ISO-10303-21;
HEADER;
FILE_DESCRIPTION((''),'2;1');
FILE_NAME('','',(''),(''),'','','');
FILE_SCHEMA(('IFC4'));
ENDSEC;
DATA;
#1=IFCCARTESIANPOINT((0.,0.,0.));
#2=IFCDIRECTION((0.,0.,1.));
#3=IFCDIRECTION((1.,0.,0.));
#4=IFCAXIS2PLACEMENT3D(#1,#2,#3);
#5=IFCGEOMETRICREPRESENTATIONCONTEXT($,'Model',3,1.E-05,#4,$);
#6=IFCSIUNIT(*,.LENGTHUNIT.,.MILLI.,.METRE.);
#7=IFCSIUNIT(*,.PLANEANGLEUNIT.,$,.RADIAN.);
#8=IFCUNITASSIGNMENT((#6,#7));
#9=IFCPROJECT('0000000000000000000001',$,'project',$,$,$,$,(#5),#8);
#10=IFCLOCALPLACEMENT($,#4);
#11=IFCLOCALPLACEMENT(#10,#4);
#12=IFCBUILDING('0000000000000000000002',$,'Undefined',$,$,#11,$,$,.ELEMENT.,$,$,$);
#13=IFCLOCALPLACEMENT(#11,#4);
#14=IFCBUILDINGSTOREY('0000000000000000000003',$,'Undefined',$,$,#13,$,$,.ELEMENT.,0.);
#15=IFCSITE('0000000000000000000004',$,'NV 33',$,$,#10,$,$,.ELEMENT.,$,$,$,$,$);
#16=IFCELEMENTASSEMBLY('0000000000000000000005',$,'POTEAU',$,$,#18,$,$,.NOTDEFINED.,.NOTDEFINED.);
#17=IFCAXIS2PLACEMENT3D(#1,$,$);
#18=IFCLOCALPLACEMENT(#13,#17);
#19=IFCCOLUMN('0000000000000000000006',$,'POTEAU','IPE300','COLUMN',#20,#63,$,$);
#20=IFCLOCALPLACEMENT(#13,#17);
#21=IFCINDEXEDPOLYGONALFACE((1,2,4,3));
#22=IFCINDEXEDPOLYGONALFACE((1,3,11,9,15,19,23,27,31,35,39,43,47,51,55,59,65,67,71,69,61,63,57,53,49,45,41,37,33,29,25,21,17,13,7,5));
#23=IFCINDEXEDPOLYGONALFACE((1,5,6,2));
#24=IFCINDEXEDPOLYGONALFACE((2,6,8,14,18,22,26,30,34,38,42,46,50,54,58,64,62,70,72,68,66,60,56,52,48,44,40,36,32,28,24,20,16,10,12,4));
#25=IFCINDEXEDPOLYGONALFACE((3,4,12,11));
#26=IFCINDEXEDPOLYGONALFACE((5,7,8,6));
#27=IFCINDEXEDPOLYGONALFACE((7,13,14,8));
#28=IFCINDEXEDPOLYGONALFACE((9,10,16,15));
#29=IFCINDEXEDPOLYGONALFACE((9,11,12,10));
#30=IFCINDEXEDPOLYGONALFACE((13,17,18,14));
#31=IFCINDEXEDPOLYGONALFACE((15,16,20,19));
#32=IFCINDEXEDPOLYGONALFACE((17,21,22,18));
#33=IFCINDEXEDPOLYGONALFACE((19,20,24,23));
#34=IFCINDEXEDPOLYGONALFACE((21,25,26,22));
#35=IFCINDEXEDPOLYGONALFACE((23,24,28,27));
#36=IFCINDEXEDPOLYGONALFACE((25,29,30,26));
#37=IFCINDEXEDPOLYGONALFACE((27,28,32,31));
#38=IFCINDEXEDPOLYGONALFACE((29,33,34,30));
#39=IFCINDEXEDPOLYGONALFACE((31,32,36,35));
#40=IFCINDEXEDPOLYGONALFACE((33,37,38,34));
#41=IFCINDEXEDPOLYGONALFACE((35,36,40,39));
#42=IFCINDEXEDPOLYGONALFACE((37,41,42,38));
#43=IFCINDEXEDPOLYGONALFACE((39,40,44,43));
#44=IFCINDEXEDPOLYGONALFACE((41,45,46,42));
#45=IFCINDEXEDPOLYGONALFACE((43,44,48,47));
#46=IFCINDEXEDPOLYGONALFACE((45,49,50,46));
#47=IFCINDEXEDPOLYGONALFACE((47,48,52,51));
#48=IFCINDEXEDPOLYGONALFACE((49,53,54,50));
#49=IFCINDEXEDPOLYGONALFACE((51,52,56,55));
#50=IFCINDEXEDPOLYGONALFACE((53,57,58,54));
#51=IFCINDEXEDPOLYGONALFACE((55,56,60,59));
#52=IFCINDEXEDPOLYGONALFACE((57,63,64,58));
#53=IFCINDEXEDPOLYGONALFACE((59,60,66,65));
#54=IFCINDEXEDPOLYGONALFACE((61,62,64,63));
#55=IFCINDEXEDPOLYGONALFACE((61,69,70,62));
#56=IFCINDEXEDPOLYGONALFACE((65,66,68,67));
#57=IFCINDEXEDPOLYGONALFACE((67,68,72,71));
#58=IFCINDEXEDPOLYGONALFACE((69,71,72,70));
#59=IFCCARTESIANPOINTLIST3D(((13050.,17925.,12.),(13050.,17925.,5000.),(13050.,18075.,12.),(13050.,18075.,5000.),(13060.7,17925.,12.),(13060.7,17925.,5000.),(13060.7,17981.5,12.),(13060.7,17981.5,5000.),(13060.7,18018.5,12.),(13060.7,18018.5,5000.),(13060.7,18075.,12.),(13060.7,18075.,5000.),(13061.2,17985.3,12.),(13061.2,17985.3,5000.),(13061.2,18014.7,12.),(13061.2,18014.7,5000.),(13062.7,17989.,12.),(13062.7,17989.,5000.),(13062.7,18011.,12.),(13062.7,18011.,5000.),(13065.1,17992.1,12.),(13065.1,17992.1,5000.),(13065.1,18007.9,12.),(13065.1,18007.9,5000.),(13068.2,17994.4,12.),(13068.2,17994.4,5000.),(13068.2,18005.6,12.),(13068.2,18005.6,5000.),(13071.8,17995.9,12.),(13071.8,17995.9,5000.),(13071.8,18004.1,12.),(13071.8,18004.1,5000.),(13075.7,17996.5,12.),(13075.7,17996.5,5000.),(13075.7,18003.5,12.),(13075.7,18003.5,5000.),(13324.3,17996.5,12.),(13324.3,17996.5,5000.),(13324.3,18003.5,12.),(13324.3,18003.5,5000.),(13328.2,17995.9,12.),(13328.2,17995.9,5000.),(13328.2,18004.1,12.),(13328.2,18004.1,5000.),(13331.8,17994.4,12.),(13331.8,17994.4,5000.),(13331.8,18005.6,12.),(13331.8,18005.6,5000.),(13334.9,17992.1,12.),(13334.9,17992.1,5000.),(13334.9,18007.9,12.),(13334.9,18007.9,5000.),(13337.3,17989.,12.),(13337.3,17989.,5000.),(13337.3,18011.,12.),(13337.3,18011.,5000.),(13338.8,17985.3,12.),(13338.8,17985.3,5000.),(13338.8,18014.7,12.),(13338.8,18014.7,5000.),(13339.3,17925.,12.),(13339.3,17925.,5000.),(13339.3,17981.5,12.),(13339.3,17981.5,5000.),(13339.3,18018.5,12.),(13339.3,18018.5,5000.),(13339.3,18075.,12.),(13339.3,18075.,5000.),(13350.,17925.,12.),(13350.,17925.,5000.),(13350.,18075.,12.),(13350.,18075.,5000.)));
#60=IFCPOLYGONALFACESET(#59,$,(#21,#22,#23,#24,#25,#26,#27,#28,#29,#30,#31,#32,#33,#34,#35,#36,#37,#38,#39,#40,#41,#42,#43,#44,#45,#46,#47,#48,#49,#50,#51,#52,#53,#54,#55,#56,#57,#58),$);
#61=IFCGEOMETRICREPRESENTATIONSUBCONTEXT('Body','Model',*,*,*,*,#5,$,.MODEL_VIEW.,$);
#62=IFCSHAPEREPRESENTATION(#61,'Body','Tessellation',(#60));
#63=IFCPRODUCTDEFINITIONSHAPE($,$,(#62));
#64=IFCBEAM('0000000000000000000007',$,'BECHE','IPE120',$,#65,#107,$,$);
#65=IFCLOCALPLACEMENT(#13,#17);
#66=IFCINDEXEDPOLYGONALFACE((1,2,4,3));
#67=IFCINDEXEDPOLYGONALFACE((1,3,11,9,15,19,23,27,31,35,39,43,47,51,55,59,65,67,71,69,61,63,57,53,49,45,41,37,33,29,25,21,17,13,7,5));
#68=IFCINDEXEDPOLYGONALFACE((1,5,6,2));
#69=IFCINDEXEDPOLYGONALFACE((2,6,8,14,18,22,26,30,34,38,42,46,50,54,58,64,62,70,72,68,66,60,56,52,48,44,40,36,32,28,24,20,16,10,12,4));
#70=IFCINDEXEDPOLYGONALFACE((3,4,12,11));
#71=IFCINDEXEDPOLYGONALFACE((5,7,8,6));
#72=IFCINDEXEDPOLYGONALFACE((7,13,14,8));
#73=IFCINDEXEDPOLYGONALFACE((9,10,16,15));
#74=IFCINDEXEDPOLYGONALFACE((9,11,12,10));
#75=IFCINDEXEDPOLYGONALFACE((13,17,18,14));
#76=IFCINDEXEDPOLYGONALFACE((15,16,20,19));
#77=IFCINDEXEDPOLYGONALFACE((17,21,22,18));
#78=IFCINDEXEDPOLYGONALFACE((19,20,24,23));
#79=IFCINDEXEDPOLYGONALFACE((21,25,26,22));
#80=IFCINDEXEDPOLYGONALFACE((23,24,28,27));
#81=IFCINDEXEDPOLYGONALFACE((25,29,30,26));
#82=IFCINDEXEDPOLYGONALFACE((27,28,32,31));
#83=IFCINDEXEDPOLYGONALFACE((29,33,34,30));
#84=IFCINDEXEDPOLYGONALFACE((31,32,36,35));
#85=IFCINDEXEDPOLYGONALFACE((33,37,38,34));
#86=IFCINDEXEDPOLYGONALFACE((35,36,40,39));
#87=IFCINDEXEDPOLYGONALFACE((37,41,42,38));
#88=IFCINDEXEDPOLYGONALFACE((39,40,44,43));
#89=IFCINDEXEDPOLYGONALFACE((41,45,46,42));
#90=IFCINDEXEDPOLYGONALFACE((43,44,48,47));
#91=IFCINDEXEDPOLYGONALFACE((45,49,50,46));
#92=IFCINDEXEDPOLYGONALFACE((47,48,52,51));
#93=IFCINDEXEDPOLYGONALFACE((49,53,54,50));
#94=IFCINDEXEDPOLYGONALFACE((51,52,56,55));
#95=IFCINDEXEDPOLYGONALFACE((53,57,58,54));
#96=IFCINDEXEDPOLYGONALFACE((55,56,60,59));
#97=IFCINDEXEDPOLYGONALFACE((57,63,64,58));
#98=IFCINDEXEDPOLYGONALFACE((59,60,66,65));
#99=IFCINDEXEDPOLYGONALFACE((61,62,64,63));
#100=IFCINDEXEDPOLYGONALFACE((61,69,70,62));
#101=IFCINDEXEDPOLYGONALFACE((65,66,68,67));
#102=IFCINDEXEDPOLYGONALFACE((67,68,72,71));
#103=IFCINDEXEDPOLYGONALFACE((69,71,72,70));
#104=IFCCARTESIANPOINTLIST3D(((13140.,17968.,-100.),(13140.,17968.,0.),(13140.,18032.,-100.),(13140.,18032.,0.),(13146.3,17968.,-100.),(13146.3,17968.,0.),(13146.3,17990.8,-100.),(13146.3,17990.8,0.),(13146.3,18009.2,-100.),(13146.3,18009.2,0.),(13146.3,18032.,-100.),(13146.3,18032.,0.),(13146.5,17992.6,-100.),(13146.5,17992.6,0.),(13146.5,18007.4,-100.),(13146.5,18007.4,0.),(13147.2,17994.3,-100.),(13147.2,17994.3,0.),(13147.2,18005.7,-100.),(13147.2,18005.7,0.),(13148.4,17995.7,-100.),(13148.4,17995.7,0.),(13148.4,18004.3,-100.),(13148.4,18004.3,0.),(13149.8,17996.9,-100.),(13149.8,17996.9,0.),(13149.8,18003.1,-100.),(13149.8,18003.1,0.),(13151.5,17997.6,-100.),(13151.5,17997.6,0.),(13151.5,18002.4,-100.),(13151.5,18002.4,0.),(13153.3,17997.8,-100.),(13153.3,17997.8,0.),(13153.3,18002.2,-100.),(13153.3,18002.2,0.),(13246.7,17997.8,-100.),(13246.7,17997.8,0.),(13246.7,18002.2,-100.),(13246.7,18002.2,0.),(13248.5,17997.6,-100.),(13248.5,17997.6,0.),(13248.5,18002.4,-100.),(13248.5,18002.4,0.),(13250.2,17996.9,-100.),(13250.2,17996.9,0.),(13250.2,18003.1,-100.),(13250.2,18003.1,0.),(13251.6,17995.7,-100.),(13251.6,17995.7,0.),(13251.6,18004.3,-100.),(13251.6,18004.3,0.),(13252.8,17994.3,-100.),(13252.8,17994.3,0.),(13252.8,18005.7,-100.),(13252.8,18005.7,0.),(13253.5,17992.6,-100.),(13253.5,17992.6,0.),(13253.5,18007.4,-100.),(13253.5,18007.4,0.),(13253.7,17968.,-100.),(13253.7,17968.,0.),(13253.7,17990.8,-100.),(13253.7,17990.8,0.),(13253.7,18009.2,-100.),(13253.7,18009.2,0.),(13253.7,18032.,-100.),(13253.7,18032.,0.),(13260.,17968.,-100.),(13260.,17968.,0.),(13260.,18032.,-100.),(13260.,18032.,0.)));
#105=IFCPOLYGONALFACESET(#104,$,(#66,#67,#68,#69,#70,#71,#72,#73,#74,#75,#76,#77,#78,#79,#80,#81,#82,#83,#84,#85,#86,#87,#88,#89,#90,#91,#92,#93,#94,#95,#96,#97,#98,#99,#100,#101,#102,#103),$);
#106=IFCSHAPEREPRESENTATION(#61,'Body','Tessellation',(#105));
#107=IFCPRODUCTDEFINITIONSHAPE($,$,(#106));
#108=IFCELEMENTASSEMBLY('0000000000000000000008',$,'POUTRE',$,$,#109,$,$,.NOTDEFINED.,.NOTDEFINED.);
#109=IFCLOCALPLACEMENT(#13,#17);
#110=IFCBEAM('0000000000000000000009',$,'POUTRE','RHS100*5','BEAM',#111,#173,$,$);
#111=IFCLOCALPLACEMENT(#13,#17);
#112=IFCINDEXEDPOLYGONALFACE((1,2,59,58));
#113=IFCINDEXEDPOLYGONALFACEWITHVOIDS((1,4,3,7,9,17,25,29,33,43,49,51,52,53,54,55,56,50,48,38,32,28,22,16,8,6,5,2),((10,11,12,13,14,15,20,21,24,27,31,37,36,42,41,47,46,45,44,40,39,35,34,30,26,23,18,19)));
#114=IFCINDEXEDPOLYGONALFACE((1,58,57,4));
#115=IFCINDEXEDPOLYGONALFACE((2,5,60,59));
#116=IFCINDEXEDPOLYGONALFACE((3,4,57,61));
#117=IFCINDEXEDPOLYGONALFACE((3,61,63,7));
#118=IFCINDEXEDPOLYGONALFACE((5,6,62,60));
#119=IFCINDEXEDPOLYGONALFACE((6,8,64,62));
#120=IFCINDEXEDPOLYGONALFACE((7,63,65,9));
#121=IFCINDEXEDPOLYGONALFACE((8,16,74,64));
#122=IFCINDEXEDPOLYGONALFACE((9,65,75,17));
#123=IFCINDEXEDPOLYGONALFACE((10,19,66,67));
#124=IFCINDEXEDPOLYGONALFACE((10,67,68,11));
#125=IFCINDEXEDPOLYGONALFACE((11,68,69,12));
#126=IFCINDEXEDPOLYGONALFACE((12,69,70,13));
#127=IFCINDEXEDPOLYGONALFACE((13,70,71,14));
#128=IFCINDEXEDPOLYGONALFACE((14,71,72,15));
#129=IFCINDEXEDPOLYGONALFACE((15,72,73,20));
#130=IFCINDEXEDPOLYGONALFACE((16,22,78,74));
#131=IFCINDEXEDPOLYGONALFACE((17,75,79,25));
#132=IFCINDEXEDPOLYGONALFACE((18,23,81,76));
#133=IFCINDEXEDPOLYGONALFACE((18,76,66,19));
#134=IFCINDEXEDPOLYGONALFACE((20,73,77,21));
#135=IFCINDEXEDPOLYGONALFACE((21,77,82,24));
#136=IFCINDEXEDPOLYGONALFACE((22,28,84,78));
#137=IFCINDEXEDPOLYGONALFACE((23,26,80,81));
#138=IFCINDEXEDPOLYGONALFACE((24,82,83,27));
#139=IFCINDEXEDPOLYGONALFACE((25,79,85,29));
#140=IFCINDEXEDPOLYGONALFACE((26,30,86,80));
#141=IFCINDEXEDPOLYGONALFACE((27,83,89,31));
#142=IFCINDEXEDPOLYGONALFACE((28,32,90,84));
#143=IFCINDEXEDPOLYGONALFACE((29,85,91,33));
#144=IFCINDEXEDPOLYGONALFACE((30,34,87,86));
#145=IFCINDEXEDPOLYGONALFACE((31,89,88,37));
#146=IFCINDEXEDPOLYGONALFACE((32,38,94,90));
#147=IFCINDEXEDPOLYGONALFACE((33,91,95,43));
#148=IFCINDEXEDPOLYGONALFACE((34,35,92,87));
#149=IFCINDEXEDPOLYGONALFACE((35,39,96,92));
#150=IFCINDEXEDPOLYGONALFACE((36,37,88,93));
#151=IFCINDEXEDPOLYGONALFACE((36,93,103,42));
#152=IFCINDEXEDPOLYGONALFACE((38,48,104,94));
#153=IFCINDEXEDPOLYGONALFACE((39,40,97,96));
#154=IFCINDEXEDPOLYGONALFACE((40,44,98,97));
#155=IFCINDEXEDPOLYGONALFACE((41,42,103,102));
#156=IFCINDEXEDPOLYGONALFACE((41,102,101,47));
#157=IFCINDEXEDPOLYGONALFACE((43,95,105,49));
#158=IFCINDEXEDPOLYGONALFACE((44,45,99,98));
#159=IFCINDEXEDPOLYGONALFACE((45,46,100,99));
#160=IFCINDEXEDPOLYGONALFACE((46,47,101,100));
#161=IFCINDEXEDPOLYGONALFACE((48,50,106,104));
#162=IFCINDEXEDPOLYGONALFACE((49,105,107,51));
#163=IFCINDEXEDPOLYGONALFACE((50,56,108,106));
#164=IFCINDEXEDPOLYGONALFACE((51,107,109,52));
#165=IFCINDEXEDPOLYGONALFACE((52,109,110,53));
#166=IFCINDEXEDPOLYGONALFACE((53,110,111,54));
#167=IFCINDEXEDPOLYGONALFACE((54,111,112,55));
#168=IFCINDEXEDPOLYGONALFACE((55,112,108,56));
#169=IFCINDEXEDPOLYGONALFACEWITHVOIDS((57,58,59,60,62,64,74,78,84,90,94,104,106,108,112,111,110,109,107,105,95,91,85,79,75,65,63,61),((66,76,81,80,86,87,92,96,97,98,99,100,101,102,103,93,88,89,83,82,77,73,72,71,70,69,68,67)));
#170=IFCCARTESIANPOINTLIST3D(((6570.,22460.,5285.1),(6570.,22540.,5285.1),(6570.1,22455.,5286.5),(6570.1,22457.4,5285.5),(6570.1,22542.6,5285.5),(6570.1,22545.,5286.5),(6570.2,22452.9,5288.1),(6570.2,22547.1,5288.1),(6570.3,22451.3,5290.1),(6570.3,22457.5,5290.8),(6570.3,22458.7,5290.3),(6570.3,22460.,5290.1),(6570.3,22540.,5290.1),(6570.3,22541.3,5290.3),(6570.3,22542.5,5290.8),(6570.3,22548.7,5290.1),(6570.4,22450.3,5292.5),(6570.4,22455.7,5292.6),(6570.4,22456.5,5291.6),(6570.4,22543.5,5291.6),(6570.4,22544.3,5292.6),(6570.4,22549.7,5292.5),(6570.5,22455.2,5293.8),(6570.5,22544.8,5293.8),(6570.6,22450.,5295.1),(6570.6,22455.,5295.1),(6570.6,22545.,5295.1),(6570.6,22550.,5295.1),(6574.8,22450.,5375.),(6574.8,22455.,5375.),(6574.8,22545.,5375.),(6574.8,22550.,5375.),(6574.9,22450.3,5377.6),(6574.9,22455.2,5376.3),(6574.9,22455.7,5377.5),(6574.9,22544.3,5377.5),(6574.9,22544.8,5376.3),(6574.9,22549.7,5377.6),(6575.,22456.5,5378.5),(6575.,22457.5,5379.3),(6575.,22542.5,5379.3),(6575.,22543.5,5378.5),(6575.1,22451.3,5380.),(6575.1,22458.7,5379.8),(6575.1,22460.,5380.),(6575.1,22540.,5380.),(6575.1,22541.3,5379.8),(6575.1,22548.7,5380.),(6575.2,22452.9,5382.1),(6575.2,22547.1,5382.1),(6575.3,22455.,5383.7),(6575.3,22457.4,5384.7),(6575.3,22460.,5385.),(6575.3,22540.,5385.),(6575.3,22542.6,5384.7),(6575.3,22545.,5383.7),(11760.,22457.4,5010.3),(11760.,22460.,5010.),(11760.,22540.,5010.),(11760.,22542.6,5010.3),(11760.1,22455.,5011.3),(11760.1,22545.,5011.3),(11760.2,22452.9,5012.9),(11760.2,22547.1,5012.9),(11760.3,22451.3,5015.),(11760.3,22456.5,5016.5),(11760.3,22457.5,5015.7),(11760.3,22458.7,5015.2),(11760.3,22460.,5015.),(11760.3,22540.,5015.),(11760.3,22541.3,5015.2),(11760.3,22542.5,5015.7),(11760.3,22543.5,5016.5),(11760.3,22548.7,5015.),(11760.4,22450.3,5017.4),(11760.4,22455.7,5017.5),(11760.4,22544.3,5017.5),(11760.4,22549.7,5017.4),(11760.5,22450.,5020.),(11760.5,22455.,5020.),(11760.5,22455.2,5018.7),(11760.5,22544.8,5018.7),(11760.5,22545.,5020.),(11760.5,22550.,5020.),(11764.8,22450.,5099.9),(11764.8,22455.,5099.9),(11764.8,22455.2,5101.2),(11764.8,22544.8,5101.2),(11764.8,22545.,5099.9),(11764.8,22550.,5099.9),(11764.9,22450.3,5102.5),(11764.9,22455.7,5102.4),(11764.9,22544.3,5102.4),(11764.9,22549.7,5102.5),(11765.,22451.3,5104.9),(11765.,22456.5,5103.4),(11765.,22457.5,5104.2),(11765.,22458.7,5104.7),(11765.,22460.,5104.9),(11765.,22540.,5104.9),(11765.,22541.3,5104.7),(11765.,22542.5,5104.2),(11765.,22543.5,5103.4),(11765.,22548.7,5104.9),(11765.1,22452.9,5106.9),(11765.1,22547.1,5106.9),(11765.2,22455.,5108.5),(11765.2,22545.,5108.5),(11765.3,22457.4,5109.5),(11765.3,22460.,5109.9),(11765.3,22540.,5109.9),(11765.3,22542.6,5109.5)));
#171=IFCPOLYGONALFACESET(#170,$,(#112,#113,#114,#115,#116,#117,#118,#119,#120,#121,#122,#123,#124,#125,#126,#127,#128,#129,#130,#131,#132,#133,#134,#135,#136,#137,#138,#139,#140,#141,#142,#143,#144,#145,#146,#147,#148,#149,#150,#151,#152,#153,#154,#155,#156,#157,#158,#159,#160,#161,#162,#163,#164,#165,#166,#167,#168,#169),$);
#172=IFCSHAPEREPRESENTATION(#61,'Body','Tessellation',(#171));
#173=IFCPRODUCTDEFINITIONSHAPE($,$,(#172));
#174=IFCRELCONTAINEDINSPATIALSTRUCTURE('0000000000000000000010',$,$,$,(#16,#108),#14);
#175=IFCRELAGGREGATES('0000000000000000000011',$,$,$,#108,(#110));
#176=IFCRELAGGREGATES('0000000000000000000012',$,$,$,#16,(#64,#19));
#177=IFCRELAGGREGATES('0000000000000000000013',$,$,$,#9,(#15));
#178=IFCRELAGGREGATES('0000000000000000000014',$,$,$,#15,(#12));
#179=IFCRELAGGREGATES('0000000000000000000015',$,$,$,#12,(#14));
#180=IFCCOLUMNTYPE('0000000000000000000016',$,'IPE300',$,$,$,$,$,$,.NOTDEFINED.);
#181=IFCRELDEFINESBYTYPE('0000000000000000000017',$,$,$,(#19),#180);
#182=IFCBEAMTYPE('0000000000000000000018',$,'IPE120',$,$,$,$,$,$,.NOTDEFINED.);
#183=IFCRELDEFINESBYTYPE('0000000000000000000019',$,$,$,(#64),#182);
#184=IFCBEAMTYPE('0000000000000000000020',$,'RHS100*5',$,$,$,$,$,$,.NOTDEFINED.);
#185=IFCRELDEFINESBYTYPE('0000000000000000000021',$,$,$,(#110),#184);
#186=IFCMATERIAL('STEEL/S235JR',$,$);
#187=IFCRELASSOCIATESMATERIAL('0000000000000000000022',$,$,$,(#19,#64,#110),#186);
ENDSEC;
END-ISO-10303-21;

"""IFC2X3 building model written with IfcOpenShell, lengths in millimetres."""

from ifc_helpers import new_model, si_unit, frame, origin_with_axes, origin_2d_with_axis, place, context, subcontext, project, spatial, hollow_rectangle, i_section, extrude, boolean, clip, halfspace, material, type_object, element, aggregate, save


model = new_model("IFC2X3")

# Units and contexts
model_context = context("Model", 3, precision=1e-05, world=origin_with_axes())
body_context = subcontext(model_context, "Body", "Model", "MODEL_VIEW")
ifc_project = project(units=[si_unit("LENGTHUNIT", "METRE", prefix="MILLI"), si_unit("PLANEANGLEUNIT", "RADIAN")], contexts=[model_context])

# Site, building, storey
site_placement = place(None, origin_with_axes())
site = spatial("IfcSite", under=ifc_project, at=site_placement, Name="NV 33", CompositionType="ELEMENT")
building_placement = place(site_placement, origin_with_axes())
building = spatial("IfcBuilding", under=site, at=building_placement, Name="Undefined", CompositionType="ELEMENT")
storey_placement = place(building_placement, origin_with_axes())
storey = spatial("IfcBuildingStorey", under=building, at=storey_placement, Name="Undefined", CompositionType="ELEMENT", Elevation=0.0)

# Element assembly, column, beam
assembly_1_placement = place(storey_placement, origin_with_axes())
assembly_1 = element("IfcElementAssembly", 1, at=assembly_1_placement, inside=storey, Name="POTEAU", AssemblyPlace="NOTDEFINED", PredefinedType="NOTDEFINED")
ifc_material_1 = material(Name="STEEL/S235JR")
column_type = type_object("IfcColumnType", Name="IPE300", PredefinedType="NOTDEFINED")
column_placement = place(assembly_1_placement, frame((13200.0, 18000.0, 0.0), z_axis=(0.0, 0.0, 1.0), x_axis=(-1.0, 0.0, 0.0)))
column = element("IfcColumn", 2, at=column_placement, type_object=column_type, material=ifc_material_1, Name="POTEAU", Description="IPE300", ObjectType="COLUMN", context=body_context, shape_type="Clipping", body=[
    clip(clip(extrude(i_section(OverallWidth=150.0, OverallDepth=300.0, WebThickness=7.1, FlangeThickness=10.7, FilletRadius=15.0, at=origin_2d_with_axis()), frame((0.0, 0.0, 5000.0), z_axis=(0.0, 0.0, -1.0), x_axis=(0.0, 1.0, 0.0)), (0.0, 0.0, 1.0), 5000.0), halfspace(frame((-150.0, 0.0, 5000.0), z_axis=(0.0, 0.0, -1.0), x_axis=(0.0, -1.0, 0.0)), True)), halfspace(frame((-150.0, 0.0, 12.0), z_axis=(0.0, 0.0, 1.0), x_axis=(0.0, 1.0, 0.0)), True)),
])
beam_type_1 = type_object("IfcBeamType", Name="IPE120", PredefinedType="NOTDEFINED")
beam_1_placement = place(assembly_1_placement, frame((13200.0, 18000.0, 0.0), z_axis=(-1.0, 0.0, 0.0), x_axis=(0.0, 0.0, -1.0)))
beam_1 = element("IfcBeam", 3, at=beam_1_placement, type_object=beam_type_1, material=ifc_material_1, Name="BECHE", Description="IPE120", context=body_context, shape_type="SweptSolid", body=[
    extrude(i_section(OverallWidth=64.0, OverallDepth=120.0, WebThickness=4.4, FlangeThickness=6.3, FilletRadius=7.0, at=origin_2d_with_axis()), frame((100.0, 0.0, 0.0), z_axis=(-1.0, 0.0, 0.0), x_axis=(0.0, -1.0, 0.0)), (0.0, 0.0, 1.0), 100.0),
])

# Shared definitions
beam_type_2 = type_object("IfcBeamType", Name="RHS100*5", PredefinedType="NOTDEFINED")

# Element assembly, beam
assembly_2_placement = place(storey_placement, origin_with_axes())
assembly_2 = element("IfcElementAssembly", 4, at=assembly_2_placement, inside=storey, Name="POUTRE", AssemblyPlace="NOTDEFINED", PredefinedType="NOTDEFINED")
beam_2_placement = place(assembly_2_placement, frame((11762.6, 22500.0, 5059.9), z_axis=(-0.052941, 0.0, -0.998598), x_axis=(-0.998598, 0.0, 0.052941)))
solid_1 = boolean("DIFFERENCE", boolean("DIFFERENCE", extrude(hollow_rectangle(XDim=100.0, YDim=100.0, WallThickness=5.0, InnerFilletRadius=5.0, OuterFilletRadius=10.0, at=origin_2d_with_axis()), frame((5142.7, 0.0, -2.9), z_axis=(0.994395, 0.0, 0.105733), x_axis=(0.0, 1.0, 0.0)), (0.0, 0.0, 1.0), 5197.2), extrude(hollow_rectangle(XDim=100.0, YDim=100.0, WallThickness=5.0, InnerFilletRadius=5.0, OuterFilletRadius=10.0, at=origin_2d_with_axis()), frame((10308.2, 0.0, 546.4), z_axis=(0.998598, 0.0, 0.052941), x_axis=(-0.052941, 0.0, 0.998598)), (0.0, 0.0, 1.0), 1600.0)), halfspace(frame((5172.5, 50.0, -50.0), z_axis=(-0.998598, 0.0, -0.052941), x_axis=(-0.052941, 0.0, 0.998598)), False))
beam_2 = element("IfcBeam", 5, at=beam_2_placement, type_object=beam_type_2, material=ifc_material_1, Name="POUTRE", Description="RHS100*5", ObjectType="BEAM", context=body_context, shape_type="CSG", body=[
    boolean("DIFFERENCE", boolean("DIFFERENCE", boolean("DIFFERENCE", extrude(hollow_rectangle(XDim=100.0, YDim=100.0, WallThickness=5.0, InnerFilletRadius=5.0, OuterFilletRadius=10.0, at=origin_2d_with_axis()), frame((5197.2, 0.0, 0.0), z_axis=(-1.0, 0.0, 0.0), x_axis=(0.0, -1.0, 0.0)), (0.0, 0.0, 1.0), 5197.2), solid_1), extrude(hollow_rectangle(XDim=100.0, YDim=100.0, WallThickness=5.0, InnerFilletRadius=5.0, OuterFilletRadius=10.0, at=origin_2d_with_axis()), frame((2.6, 0.0, 0.1), z_axis=(-0.998598, 0.0, -0.052941), x_axis=(0.052941, 0.0, -0.998598)), (0.0, 0.0, 1.0), 1600.0)), halfspace(frame((5172.5, 50.0, -50.0), z_axis=(0.998598, 0.0, 0.052941), x_axis=(0.0, -1.0, 0.0)), False)),
])
aggregate(assembly_2, [beam_2])

aggregate(assembly_1, [beam_1, column])

save(model, "model.ifc")
